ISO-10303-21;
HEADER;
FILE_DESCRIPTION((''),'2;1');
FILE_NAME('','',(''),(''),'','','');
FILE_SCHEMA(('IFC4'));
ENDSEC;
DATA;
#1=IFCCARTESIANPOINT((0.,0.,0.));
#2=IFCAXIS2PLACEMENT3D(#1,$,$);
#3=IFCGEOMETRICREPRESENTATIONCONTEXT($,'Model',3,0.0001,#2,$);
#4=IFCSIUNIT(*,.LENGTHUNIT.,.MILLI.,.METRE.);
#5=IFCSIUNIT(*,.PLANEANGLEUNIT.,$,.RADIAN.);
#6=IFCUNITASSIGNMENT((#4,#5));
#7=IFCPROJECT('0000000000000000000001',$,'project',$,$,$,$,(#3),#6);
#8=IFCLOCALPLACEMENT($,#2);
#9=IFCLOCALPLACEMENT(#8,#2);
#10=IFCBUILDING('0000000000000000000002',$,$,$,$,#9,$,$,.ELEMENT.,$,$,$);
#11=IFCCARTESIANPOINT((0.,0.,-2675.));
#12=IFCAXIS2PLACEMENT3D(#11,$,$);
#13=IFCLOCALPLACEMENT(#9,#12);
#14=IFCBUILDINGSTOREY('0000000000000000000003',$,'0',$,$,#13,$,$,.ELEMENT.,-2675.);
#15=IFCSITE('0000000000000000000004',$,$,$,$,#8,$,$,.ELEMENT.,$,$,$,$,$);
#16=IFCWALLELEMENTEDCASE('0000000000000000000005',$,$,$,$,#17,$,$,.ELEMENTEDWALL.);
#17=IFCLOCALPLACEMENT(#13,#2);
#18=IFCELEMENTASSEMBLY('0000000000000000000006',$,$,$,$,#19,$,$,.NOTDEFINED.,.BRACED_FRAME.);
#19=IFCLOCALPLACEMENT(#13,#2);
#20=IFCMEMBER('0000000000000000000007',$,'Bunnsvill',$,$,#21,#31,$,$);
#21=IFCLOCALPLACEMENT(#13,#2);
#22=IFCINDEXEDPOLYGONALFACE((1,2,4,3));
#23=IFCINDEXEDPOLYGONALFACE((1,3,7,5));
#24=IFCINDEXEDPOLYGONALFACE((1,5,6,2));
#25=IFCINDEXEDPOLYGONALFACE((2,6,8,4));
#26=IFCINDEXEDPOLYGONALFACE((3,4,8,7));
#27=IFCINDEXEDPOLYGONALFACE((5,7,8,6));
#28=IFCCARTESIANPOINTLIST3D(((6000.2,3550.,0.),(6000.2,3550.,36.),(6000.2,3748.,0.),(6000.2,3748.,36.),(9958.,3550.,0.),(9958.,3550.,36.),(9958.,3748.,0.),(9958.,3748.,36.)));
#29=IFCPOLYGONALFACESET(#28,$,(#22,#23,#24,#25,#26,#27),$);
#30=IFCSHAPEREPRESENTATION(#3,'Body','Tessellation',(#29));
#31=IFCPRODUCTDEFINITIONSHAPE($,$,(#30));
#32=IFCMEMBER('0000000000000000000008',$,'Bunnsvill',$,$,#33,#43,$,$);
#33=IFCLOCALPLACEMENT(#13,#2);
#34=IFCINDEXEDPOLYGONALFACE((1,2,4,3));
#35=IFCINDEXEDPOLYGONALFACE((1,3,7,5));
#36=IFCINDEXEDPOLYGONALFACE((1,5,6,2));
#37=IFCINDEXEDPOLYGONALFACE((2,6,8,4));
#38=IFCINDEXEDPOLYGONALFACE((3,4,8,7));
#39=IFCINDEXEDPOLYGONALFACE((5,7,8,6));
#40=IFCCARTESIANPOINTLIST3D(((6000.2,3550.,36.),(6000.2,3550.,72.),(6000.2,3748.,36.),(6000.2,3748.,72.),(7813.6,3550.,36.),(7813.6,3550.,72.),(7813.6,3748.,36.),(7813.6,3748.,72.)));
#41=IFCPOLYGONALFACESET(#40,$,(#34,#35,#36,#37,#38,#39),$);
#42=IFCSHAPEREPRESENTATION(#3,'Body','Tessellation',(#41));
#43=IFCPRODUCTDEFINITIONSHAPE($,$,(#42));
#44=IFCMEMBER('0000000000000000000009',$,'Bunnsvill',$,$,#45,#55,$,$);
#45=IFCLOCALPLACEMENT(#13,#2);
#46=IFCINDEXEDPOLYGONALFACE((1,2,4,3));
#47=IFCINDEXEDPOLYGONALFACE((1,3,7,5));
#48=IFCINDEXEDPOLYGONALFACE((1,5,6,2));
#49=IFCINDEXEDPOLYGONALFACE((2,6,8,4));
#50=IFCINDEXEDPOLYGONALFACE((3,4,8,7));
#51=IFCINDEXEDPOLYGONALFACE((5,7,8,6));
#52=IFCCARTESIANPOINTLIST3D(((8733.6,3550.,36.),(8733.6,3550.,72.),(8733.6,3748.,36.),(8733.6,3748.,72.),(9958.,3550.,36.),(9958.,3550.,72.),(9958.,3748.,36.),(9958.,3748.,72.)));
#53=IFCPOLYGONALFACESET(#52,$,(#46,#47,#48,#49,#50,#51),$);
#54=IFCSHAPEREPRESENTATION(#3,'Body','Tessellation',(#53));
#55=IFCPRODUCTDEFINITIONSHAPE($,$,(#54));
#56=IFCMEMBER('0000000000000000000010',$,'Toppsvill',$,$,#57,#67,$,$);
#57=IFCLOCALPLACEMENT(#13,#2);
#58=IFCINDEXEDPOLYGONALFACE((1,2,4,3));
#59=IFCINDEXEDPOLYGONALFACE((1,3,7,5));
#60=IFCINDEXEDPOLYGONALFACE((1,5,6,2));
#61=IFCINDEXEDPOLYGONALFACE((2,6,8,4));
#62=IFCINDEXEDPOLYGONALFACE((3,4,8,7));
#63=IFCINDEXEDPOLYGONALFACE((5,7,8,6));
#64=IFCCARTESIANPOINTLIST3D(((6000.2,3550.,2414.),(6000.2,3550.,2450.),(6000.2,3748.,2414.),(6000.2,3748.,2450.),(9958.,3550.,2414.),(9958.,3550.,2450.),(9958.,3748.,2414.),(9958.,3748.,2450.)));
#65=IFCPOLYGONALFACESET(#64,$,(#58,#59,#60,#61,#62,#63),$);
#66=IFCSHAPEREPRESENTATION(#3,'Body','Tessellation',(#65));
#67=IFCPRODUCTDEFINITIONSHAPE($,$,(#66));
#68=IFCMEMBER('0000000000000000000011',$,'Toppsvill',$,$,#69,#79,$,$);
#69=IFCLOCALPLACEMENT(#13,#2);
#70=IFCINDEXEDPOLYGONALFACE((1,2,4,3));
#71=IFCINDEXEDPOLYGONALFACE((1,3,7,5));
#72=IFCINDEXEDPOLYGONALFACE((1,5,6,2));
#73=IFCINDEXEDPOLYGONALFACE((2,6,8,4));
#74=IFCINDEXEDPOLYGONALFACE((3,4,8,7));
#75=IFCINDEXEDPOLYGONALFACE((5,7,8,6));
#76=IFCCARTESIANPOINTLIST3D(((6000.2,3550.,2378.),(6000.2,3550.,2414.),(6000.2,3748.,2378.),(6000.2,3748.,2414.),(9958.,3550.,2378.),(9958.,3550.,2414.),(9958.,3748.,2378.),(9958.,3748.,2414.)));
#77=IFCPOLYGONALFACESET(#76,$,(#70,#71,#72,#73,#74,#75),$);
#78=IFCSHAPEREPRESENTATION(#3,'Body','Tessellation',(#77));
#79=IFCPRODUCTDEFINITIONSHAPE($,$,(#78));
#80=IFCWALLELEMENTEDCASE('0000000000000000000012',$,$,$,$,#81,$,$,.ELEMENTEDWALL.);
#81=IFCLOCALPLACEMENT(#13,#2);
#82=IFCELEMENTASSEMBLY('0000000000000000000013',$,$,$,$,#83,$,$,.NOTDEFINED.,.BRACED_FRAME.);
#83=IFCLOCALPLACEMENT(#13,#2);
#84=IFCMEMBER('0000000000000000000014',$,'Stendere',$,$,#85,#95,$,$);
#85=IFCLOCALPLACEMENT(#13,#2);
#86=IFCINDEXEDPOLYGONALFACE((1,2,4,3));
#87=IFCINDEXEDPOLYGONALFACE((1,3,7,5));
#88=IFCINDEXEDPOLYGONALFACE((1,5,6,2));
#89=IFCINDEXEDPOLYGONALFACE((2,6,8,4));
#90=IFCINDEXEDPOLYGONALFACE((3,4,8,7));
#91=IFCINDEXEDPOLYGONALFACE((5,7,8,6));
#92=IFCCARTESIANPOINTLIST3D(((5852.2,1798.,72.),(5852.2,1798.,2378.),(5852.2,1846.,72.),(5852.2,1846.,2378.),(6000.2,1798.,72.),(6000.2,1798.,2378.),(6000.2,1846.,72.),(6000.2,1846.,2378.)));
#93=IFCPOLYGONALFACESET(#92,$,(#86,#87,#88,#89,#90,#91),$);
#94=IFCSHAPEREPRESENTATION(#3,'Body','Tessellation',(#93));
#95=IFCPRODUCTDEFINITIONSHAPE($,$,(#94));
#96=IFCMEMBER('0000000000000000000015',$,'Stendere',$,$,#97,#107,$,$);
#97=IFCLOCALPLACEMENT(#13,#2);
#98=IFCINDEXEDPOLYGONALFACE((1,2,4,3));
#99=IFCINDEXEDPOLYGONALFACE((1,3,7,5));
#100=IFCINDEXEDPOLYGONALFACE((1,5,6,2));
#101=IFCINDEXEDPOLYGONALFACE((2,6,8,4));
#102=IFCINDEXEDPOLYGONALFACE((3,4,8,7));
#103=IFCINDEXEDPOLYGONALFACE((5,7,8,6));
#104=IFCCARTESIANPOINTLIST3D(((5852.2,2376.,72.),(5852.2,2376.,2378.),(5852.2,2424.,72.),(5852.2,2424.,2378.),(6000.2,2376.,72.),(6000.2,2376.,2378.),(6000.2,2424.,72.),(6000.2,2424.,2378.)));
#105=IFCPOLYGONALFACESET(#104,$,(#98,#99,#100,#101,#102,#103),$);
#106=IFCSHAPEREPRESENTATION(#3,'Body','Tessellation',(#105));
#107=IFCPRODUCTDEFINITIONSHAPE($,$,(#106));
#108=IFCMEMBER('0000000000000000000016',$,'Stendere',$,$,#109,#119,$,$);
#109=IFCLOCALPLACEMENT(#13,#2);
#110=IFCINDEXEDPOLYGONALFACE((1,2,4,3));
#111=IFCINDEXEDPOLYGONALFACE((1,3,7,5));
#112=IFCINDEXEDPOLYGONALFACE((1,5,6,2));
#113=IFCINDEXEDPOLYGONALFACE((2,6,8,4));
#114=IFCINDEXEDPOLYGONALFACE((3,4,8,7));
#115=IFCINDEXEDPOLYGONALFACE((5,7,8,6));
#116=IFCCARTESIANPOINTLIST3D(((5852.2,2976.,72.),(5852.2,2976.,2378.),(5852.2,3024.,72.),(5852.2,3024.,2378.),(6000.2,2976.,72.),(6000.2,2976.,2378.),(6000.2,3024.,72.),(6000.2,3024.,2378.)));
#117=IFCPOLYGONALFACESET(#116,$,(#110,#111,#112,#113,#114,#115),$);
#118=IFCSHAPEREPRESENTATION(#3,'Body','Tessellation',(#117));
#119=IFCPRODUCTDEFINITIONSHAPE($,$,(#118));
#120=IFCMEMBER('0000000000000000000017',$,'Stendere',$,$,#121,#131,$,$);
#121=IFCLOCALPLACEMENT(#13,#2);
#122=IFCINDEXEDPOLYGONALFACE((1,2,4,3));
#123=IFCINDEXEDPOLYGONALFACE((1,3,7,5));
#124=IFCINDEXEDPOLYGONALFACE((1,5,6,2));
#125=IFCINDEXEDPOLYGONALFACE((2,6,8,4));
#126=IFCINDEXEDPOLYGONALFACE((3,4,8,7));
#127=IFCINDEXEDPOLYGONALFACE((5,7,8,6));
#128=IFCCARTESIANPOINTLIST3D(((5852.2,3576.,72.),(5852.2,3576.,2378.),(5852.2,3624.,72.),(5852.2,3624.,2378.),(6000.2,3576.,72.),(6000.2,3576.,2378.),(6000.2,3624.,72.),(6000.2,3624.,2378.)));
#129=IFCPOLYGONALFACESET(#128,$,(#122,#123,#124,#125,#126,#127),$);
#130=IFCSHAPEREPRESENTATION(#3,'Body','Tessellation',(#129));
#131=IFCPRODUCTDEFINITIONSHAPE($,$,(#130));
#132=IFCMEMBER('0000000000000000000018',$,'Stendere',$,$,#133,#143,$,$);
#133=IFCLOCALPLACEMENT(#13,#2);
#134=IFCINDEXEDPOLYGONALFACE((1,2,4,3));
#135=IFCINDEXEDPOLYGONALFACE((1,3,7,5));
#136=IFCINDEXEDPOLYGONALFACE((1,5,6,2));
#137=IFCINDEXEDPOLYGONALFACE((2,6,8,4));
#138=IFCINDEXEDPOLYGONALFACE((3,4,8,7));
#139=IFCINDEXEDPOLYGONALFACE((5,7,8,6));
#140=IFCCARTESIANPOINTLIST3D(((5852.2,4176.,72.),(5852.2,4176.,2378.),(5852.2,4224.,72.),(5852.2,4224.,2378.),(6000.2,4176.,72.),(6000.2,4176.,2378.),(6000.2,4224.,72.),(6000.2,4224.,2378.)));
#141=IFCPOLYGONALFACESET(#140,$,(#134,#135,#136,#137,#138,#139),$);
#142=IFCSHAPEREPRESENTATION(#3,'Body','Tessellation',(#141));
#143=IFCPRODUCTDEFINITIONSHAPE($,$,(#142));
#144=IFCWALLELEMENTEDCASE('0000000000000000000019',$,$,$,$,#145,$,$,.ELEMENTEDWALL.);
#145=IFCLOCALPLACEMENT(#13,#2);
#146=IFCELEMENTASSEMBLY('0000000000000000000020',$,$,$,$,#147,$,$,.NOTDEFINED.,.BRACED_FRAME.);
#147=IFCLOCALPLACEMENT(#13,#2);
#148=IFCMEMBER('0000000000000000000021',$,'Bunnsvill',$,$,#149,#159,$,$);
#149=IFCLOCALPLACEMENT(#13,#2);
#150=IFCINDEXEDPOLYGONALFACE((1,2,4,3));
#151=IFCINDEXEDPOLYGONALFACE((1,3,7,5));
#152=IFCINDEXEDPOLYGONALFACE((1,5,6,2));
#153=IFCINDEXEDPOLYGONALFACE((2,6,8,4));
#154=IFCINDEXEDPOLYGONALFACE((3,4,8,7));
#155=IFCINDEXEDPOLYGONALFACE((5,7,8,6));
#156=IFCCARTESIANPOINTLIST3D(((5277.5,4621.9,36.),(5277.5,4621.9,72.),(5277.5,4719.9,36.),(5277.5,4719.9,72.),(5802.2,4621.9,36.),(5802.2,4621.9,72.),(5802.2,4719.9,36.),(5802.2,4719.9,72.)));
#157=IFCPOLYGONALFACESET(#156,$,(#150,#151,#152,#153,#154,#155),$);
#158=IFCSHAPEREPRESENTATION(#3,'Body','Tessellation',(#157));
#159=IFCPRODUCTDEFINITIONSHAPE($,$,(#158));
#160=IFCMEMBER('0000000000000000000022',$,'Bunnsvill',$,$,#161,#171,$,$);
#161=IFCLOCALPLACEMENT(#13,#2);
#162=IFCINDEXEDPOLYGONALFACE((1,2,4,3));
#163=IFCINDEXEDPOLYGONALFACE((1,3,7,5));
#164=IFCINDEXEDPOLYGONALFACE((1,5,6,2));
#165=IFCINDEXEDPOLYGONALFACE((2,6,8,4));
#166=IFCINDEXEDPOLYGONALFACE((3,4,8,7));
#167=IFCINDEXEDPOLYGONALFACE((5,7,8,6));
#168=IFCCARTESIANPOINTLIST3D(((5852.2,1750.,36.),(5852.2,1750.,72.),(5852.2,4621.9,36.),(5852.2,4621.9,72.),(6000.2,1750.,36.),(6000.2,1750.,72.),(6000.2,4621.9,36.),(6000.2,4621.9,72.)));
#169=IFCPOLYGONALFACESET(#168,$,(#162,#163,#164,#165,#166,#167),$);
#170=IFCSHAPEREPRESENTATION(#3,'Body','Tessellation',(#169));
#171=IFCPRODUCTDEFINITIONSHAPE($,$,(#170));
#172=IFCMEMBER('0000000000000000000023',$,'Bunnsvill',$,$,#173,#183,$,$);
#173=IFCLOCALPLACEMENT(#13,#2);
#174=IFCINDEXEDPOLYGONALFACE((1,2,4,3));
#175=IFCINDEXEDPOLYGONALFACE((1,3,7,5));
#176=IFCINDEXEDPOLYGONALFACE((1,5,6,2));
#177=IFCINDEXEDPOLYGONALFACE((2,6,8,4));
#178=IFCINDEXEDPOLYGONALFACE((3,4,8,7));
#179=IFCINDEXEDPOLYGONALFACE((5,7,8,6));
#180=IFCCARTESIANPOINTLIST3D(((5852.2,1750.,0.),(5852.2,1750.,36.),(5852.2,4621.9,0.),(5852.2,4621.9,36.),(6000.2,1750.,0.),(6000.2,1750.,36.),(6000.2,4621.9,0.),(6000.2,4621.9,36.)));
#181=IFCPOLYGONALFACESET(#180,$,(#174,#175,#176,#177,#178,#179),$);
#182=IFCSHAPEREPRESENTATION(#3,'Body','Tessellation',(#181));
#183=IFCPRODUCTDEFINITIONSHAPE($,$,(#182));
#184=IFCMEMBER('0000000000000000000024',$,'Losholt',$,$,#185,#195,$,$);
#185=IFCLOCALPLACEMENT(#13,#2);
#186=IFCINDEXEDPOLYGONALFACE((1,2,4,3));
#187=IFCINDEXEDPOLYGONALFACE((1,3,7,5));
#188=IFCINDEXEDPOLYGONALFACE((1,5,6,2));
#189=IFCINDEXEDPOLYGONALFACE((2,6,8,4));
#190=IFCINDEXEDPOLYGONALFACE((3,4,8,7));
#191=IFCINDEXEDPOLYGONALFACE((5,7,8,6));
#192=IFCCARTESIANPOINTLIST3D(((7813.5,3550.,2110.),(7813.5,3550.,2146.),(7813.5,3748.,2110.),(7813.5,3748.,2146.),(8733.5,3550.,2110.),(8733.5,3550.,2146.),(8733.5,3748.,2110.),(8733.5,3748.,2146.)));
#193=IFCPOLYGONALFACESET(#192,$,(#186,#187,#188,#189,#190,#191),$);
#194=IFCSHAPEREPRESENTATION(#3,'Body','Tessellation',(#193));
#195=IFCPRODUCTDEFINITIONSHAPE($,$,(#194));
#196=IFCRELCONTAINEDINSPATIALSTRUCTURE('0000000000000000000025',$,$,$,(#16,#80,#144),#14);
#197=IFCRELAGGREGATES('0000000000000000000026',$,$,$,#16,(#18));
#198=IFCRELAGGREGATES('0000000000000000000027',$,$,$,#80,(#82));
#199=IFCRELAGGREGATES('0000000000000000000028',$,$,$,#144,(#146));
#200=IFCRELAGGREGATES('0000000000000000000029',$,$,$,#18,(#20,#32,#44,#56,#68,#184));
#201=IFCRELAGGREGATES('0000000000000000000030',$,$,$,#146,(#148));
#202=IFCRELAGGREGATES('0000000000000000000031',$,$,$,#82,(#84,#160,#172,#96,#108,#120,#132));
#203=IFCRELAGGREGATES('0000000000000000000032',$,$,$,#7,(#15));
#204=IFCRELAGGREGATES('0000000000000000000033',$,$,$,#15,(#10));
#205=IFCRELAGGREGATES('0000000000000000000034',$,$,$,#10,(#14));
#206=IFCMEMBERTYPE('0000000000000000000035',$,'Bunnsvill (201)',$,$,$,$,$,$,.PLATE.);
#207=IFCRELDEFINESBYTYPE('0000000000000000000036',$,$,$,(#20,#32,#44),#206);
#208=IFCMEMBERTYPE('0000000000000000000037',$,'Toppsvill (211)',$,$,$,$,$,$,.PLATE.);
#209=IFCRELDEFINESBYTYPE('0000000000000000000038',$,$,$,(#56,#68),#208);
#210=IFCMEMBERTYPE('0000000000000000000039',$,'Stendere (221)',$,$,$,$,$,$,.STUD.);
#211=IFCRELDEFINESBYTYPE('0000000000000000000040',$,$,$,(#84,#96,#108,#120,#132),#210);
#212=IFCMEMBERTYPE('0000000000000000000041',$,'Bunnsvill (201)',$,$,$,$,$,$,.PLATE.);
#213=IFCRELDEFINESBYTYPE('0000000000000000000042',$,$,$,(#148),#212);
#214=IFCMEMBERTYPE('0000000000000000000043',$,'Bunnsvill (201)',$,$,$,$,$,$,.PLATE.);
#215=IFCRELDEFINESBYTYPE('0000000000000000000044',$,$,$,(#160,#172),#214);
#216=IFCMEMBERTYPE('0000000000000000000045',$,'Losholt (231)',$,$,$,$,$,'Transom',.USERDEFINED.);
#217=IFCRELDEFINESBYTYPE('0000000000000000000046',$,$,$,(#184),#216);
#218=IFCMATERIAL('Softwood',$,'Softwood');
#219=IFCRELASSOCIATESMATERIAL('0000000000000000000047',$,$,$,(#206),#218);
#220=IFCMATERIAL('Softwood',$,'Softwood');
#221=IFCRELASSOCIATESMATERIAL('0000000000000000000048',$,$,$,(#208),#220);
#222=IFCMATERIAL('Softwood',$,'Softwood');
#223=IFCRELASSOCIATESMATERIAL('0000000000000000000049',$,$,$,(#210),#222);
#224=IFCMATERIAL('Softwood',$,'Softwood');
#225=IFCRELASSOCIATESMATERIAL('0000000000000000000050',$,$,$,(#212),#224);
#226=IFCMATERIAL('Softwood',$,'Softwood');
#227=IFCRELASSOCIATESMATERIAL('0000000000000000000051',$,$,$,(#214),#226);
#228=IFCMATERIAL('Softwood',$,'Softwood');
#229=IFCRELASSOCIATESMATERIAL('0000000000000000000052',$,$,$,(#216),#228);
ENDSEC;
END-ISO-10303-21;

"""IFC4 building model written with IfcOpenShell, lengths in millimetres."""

from ifc_helpers import new_model, si_unit, frame, origin, place, context, project, spatial, rectangle, extrude, clip, halfspace, material, material_profile, profile_set, type_object, element, aggregate, save


model = new_model("IFC4")

# Units and contexts
model_context = context("Model", 3, precision=0.0001, world=origin())
ifc_project = project(units=[si_unit("LENGTHUNIT", "METRE", prefix="MILLI"), si_unit("PLANEANGLEUNIT", "RADIAN")], contexts=[model_context])

# Site, building, storey
site_placement = place(None, origin())
site = spatial("IfcSite", under=ifc_project, at=site_placement, CompositionType="ELEMENT")
building_placement = place(site_placement, origin())
building = spatial("IfcBuilding", under=site, at=building_placement, CompositionType="ELEMENT")
storey_placement = place(building_placement, frame((0.0, 0.0, -2675.0)))
storey = spatial("IfcBuildingStorey", under=building, at=storey_placement, Name="0", CompositionType="ELEMENT", Elevation=-2675.0)

# Wall, element assembly
wall_1_placement = place(storey_placement, frame((6000.2, 3748.0, 0.0), z_axis=(0.0, -1.0, 0.0)))
wall_1 = element("IfcWallElementedCase", 1, at=wall_1_placement, inside=storey, PredefinedType="ELEMENTEDWALL")
assembly_1_placement = place(wall_1_placement, origin())
assembly_1 = element("IfcElementAssembly", 2, at=assembly_1_placement, AssemblyPlace="NOTDEFINED", PredefinedType="BRACED_FRAME")
aggregate(wall_1, [assembly_1])

# Members
ifc_material_1 = material(Name="Softwood", Category="Softwood")
ifc_material_profile_1 = material_profile(ifc_material_1, rectangle(XDim=36.0, YDim=198.0), Name="Bunnsvill (201)")
ifc_profile_set_1 = profile_set([ifc_material_profile_1])
member_type_1 = type_object("IfcMemberType", Name="Bunnsvill (201)", PredefinedType="PLATE", material=ifc_profile_set_1)
member_1_placement = place(assembly_1_placement, frame((0.0, 18.0, 0.0), z_axis=(1.0, 0.0, 0.0), x_axis=(0.0, 1.0, 0.0)))
member_1 = element("IfcMember", 3, at=member_1_placement, type_object=member_type_1, Name="Bunnsvill", context=model_context, shape_type="SweptSolid", body=[
    extrude(rectangle(XDim=36.0, YDim=198.0), frame((0.0, 99.0, 0.0)), (0.0, 0.0, 1.0), 3957.8),
])
member_2_placement = place(assembly_1_placement, frame((0.0, 54.0, 0.0), z_axis=(1.0, 0.0, 0.0), x_axis=(0.0, 1.0, 0.0)))
member_2 = element("IfcMember", 4, at=member_2_placement, type_object=member_type_1, Name="Bunnsvill", context=model_context, shape_type="SweptSolid", body=[
    extrude(rectangle(XDim=36.0, YDim=198.0), frame((0.0, 99.0, 0.0)), (0.0, 0.0, 1.0), 1813.4),
])
member_3_placement = place(assembly_1_placement, frame((2733.4, 54.0, 0.0), z_axis=(1.0, 0.0, 0.0), x_axis=(0.0, 1.0, 0.0)))
member_3 = element("IfcMember", 5, at=member_3_placement, type_object=member_type_1, Name="Bunnsvill", context=model_context, shape_type="SweptSolid", body=[
    extrude(rectangle(XDim=36.0, YDim=198.0), frame((0.0, 99.0, 0.0)), (0.0, 0.0, 1.0), 1224.4),
])
ifc_material_2 = material(Name="Softwood", Category="Softwood")
ifc_material_profile_2 = material_profile(ifc_material_2, rectangle(XDim=36.0, YDim=198.0), Name="Toppsvill (211)")
ifc_profile_set_2 = profile_set([ifc_material_profile_2])
member_type_2 = type_object("IfcMemberType", Name="Toppsvill (211)", PredefinedType="PLATE", material=ifc_profile_set_2)
member_4_placement = place(assembly_1_placement, frame((0.0, 2432.0, 0.0), z_axis=(1.0, 0.0, 0.0), x_axis=(0.0, 1.0, 0.0)))
member_4 = element("IfcMember", 6, at=member_4_placement, type_object=member_type_2, Name="Toppsvill", context=model_context, shape_type="Clipping", body=[
    clip(extrude(rectangle(XDim=36.0, YDim=198.0), frame((0.0, 99.0, 0.0)), (0.0, 0.0, 1.0), 3957.8), halfspace(frame((0.0, 99.0, 0.0)), True)),
])
member_5_placement = place(assembly_1_placement, frame((0.0, 2396.0, 0.0), z_axis=(1.0, 0.0, 0.0), x_axis=(0.0, 1.0, 0.0)))
member_5 = element("IfcMember", 7, at=member_5_placement, type_object=member_type_2, Name="Toppsvill", context=model_context, shape_type="Clipping", body=[
    clip(extrude(rectangle(XDim=36.0, YDim=198.0), frame((0.0, 99.0, 0.0)), (0.0, 0.0, 1.0), 3957.8), halfspace(frame((0.0, 99.0, 0.0)), True)),
])

# Wall, element assembly, members
wall_2_placement = place(storey_placement, frame((5852.2, 1750.0, 0.0), z_axis=(1.0, 0.0, 0.0), x_axis=(0.0, 1.0, 0.0)))
wall_2 = element("IfcWallElementedCase", 8, at=wall_2_placement, inside=storey, PredefinedType="ELEMENTEDWALL")
assembly_2_placement = place(wall_2_placement, origin())
assembly_2 = element("IfcElementAssembly", 9, at=assembly_2_placement, AssemblyPlace="NOTDEFINED", PredefinedType="BRACED_FRAME")
aggregate(wall_2, [assembly_2])
ifc_material_3 = material(Name="Softwood", Category="Softwood")
ifc_material_profile_3 = material_profile(ifc_material_3, rectangle(XDim=48.0, YDim=148.0), Name="Stendere (221)")
ifc_profile_set_3 = profile_set([ifc_material_profile_3])
member_type_3 = type_object("IfcMemberType", Name="Stendere (221)", PredefinedType="STUD", material=ifc_profile_set_3)
member_6_placement = place(assembly_2_placement, frame((72.0, 72.0, 0.0), z_axis=(0.0, 1.0, 0.0), x_axis=(-1.0, 0.0, 0.0)))
member_6 = element("IfcMember", 10, at=member_6_placement, type_object=member_type_3, Name="Stendere", context=model_context, shape_type="SweptSolid", body=[
    extrude(rectangle(XDim=48.0, YDim=148.0), frame((0.0, 74.0, 0.0)), (0.0, 0.0, 1.0), 2306.0),
])
member_7_placement = place(assembly_2_placement, frame((650.0, 72.0, 0.0), z_axis=(0.0, 1.0, 0.0), x_axis=(-1.0, 0.0, 0.0)))
member_7 = element("IfcMember", 11, at=member_7_placement, type_object=member_type_3, Name="Stendere", context=model_context, shape_type="SweptSolid", body=[
    extrude(rectangle(XDim=48.0, YDim=148.0), frame((0.0, 74.0, 0.0)), (0.0, 0.0, 1.0), 2306.0),
])
member_8_placement = place(assembly_2_placement, frame((1250.0, 72.0, 0.0), z_axis=(0.0, 1.0, 0.0), x_axis=(-1.0, 0.0, 0.0)))
member_8 = element("IfcMember", 12, at=member_8_placement, type_object=member_type_3, Name="Stendere", context=model_context, shape_type="SweptSolid", body=[
    extrude(rectangle(XDim=48.0, YDim=148.0), frame((0.0, 74.0, 0.0)), (0.0, 0.0, 1.0), 2306.0),
])
member_9_placement = place(assembly_2_placement, frame((1850.0, 72.0, 0.0), z_axis=(0.0, 1.0, 0.0), x_axis=(-1.0, 0.0, 0.0)))
member_9 = element("IfcMember", 13, at=member_9_placement, type_object=member_type_3, Name="Stendere", context=model_context, shape_type="SweptSolid", body=[
    extrude(rectangle(XDim=48.0, YDim=148.0), frame((0.0, 74.0, 0.0)), (0.0, 0.0, 1.0), 2306.0),
])
member_10_placement = place(assembly_2_placement, frame((2450.0, 72.0, 0.0), z_axis=(0.0, 1.0, 0.0), x_axis=(-1.0, 0.0, 0.0)))
member_10 = element("IfcMember", 14, at=member_10_placement, type_object=member_type_3, Name="Stendere", context=model_context, shape_type="SweptSolid", body=[
    extrude(rectangle(XDim=48.0, YDim=148.0), frame((0.0, 74.0, 0.0)), (0.0, 0.0, 1.0), 2306.0),
])

# Wall, element assembly, member
wall_3_placement = place(storey_placement, frame((352.0, 4719.9, 0.0), z_axis=(0.0, -1.0, 0.0)))
wall_3 = element("IfcWallElementedCase", 15, at=wall_3_placement, inside=storey, PredefinedType="ELEMENTEDWALL")
assembly_3_placement = place(wall_3_placement, origin())
assembly_3 = element("IfcElementAssembly", 16, at=assembly_3_placement, AssemblyPlace="NOTDEFINED", PredefinedType="BRACED_FRAME")
aggregate(wall_3, [assembly_3])
ifc_material_4 = material(Name="Softwood", Category="Softwood")
ifc_material_profile_4 = material_profile(ifc_material_4, rectangle(XDim=36.0, YDim=98.0), Name="Bunnsvill (201)")
ifc_profile_set_4 = profile_set([ifc_material_profile_4])
member_type_4 = type_object("IfcMemberType", Name="Bunnsvill (201)", PredefinedType="PLATE", material=ifc_profile_set_4)
member_11_placement = place(assembly_3_placement, frame((4925.5, 54.0, 0.0), z_axis=(1.0, 0.0, 0.0), x_axis=(0.0, 1.0, 0.0)))
member_11 = element("IfcMember", 17, at=member_11_placement, type_object=member_type_4, Name="Bunnsvill", context=model_context, shape_type="SweptSolid", body=[
    extrude(rectangle(XDim=36.0, YDim=98.0), frame((0.0, 49.0, 0.0)), (0.0, 0.0, 1.0), 524.7),
])

# Members
ifc_material_5 = material(Name="Softwood", Category="Softwood")
ifc_material_profile_5 = material_profile(ifc_material_5, rectangle(XDim=36.0, YDim=148.0), Name="Bunnsvill (201)")
ifc_profile_set_5 = profile_set([ifc_material_profile_5])
member_type_5 = type_object("IfcMemberType", Name="Bunnsvill (201)", PredefinedType="PLATE", material=ifc_profile_set_5)
member_12_placement = place(assembly_2_placement, frame((0.0, 54.0, 0.0), z_axis=(1.0, 0.0, 0.0), x_axis=(0.0, 1.0, 0.0)))
member_12 = element("IfcMember", 18, at=member_12_placement, type_object=member_type_5, Name="Bunnsvill", context=model_context, shape_type="SweptSolid", body=[
    extrude(rectangle(XDim=36.0, YDim=148.0), frame((0.0, 74.0, 0.0)), (0.0, 0.0, 1.0), 2871.9),
])
member_13_placement = place(assembly_2_placement, frame((0.0, 18.0, 0.0), z_axis=(1.0, 0.0, 0.0), x_axis=(0.0, 1.0, 0.0)))
member_13 = element("IfcMember", 19, at=member_13_placement, type_object=member_type_5, Name="Bunnsvill", context=model_context, shape_type="SweptSolid", body=[
    extrude(rectangle(XDim=36.0, YDim=148.0), frame((0.0, 74.0, 0.0)), (0.0, 0.0, 1.0), 2871.9),
])
ifc_material_6 = material(Name="Softwood", Category="Softwood")
ifc_material_profile_6 = material_profile(ifc_material_6, rectangle(XDim=36.0, YDim=198.0), Name="Losholt (231)")
ifc_profile_set_6 = profile_set([ifc_material_profile_6])
member_type_6 = type_object("IfcMemberType", Name="Losholt (231)", ElementType="Transom", PredefinedType="USERDEFINED", material=ifc_profile_set_6)
member_14_placement = place(assembly_1_placement, frame((1813.4, 2128.0, 0.0), z_axis=(1.0, 0.0, 0.0), x_axis=(0.0, 1.0, 0.0)))
member_14 = element("IfcMember", 20, at=member_14_placement, type_object=member_type_6, Name="Losholt", context=model_context, shape_type="SweptSolid", body=[
    extrude(rectangle(XDim=36.0, YDim=198.0), frame((0.0, 99.0, 0.0)), (0.0, 0.0, 1.0), 920.0),
])

aggregate(assembly_1, [member_1, member_2, member_3, member_4, member_5, member_14])

aggregate(assembly_3, [member_11])
aggregate(assembly_2, [member_6, member_12, member_13, member_7, member_8, member_9, member_10])

save(model, "model.ifc")
